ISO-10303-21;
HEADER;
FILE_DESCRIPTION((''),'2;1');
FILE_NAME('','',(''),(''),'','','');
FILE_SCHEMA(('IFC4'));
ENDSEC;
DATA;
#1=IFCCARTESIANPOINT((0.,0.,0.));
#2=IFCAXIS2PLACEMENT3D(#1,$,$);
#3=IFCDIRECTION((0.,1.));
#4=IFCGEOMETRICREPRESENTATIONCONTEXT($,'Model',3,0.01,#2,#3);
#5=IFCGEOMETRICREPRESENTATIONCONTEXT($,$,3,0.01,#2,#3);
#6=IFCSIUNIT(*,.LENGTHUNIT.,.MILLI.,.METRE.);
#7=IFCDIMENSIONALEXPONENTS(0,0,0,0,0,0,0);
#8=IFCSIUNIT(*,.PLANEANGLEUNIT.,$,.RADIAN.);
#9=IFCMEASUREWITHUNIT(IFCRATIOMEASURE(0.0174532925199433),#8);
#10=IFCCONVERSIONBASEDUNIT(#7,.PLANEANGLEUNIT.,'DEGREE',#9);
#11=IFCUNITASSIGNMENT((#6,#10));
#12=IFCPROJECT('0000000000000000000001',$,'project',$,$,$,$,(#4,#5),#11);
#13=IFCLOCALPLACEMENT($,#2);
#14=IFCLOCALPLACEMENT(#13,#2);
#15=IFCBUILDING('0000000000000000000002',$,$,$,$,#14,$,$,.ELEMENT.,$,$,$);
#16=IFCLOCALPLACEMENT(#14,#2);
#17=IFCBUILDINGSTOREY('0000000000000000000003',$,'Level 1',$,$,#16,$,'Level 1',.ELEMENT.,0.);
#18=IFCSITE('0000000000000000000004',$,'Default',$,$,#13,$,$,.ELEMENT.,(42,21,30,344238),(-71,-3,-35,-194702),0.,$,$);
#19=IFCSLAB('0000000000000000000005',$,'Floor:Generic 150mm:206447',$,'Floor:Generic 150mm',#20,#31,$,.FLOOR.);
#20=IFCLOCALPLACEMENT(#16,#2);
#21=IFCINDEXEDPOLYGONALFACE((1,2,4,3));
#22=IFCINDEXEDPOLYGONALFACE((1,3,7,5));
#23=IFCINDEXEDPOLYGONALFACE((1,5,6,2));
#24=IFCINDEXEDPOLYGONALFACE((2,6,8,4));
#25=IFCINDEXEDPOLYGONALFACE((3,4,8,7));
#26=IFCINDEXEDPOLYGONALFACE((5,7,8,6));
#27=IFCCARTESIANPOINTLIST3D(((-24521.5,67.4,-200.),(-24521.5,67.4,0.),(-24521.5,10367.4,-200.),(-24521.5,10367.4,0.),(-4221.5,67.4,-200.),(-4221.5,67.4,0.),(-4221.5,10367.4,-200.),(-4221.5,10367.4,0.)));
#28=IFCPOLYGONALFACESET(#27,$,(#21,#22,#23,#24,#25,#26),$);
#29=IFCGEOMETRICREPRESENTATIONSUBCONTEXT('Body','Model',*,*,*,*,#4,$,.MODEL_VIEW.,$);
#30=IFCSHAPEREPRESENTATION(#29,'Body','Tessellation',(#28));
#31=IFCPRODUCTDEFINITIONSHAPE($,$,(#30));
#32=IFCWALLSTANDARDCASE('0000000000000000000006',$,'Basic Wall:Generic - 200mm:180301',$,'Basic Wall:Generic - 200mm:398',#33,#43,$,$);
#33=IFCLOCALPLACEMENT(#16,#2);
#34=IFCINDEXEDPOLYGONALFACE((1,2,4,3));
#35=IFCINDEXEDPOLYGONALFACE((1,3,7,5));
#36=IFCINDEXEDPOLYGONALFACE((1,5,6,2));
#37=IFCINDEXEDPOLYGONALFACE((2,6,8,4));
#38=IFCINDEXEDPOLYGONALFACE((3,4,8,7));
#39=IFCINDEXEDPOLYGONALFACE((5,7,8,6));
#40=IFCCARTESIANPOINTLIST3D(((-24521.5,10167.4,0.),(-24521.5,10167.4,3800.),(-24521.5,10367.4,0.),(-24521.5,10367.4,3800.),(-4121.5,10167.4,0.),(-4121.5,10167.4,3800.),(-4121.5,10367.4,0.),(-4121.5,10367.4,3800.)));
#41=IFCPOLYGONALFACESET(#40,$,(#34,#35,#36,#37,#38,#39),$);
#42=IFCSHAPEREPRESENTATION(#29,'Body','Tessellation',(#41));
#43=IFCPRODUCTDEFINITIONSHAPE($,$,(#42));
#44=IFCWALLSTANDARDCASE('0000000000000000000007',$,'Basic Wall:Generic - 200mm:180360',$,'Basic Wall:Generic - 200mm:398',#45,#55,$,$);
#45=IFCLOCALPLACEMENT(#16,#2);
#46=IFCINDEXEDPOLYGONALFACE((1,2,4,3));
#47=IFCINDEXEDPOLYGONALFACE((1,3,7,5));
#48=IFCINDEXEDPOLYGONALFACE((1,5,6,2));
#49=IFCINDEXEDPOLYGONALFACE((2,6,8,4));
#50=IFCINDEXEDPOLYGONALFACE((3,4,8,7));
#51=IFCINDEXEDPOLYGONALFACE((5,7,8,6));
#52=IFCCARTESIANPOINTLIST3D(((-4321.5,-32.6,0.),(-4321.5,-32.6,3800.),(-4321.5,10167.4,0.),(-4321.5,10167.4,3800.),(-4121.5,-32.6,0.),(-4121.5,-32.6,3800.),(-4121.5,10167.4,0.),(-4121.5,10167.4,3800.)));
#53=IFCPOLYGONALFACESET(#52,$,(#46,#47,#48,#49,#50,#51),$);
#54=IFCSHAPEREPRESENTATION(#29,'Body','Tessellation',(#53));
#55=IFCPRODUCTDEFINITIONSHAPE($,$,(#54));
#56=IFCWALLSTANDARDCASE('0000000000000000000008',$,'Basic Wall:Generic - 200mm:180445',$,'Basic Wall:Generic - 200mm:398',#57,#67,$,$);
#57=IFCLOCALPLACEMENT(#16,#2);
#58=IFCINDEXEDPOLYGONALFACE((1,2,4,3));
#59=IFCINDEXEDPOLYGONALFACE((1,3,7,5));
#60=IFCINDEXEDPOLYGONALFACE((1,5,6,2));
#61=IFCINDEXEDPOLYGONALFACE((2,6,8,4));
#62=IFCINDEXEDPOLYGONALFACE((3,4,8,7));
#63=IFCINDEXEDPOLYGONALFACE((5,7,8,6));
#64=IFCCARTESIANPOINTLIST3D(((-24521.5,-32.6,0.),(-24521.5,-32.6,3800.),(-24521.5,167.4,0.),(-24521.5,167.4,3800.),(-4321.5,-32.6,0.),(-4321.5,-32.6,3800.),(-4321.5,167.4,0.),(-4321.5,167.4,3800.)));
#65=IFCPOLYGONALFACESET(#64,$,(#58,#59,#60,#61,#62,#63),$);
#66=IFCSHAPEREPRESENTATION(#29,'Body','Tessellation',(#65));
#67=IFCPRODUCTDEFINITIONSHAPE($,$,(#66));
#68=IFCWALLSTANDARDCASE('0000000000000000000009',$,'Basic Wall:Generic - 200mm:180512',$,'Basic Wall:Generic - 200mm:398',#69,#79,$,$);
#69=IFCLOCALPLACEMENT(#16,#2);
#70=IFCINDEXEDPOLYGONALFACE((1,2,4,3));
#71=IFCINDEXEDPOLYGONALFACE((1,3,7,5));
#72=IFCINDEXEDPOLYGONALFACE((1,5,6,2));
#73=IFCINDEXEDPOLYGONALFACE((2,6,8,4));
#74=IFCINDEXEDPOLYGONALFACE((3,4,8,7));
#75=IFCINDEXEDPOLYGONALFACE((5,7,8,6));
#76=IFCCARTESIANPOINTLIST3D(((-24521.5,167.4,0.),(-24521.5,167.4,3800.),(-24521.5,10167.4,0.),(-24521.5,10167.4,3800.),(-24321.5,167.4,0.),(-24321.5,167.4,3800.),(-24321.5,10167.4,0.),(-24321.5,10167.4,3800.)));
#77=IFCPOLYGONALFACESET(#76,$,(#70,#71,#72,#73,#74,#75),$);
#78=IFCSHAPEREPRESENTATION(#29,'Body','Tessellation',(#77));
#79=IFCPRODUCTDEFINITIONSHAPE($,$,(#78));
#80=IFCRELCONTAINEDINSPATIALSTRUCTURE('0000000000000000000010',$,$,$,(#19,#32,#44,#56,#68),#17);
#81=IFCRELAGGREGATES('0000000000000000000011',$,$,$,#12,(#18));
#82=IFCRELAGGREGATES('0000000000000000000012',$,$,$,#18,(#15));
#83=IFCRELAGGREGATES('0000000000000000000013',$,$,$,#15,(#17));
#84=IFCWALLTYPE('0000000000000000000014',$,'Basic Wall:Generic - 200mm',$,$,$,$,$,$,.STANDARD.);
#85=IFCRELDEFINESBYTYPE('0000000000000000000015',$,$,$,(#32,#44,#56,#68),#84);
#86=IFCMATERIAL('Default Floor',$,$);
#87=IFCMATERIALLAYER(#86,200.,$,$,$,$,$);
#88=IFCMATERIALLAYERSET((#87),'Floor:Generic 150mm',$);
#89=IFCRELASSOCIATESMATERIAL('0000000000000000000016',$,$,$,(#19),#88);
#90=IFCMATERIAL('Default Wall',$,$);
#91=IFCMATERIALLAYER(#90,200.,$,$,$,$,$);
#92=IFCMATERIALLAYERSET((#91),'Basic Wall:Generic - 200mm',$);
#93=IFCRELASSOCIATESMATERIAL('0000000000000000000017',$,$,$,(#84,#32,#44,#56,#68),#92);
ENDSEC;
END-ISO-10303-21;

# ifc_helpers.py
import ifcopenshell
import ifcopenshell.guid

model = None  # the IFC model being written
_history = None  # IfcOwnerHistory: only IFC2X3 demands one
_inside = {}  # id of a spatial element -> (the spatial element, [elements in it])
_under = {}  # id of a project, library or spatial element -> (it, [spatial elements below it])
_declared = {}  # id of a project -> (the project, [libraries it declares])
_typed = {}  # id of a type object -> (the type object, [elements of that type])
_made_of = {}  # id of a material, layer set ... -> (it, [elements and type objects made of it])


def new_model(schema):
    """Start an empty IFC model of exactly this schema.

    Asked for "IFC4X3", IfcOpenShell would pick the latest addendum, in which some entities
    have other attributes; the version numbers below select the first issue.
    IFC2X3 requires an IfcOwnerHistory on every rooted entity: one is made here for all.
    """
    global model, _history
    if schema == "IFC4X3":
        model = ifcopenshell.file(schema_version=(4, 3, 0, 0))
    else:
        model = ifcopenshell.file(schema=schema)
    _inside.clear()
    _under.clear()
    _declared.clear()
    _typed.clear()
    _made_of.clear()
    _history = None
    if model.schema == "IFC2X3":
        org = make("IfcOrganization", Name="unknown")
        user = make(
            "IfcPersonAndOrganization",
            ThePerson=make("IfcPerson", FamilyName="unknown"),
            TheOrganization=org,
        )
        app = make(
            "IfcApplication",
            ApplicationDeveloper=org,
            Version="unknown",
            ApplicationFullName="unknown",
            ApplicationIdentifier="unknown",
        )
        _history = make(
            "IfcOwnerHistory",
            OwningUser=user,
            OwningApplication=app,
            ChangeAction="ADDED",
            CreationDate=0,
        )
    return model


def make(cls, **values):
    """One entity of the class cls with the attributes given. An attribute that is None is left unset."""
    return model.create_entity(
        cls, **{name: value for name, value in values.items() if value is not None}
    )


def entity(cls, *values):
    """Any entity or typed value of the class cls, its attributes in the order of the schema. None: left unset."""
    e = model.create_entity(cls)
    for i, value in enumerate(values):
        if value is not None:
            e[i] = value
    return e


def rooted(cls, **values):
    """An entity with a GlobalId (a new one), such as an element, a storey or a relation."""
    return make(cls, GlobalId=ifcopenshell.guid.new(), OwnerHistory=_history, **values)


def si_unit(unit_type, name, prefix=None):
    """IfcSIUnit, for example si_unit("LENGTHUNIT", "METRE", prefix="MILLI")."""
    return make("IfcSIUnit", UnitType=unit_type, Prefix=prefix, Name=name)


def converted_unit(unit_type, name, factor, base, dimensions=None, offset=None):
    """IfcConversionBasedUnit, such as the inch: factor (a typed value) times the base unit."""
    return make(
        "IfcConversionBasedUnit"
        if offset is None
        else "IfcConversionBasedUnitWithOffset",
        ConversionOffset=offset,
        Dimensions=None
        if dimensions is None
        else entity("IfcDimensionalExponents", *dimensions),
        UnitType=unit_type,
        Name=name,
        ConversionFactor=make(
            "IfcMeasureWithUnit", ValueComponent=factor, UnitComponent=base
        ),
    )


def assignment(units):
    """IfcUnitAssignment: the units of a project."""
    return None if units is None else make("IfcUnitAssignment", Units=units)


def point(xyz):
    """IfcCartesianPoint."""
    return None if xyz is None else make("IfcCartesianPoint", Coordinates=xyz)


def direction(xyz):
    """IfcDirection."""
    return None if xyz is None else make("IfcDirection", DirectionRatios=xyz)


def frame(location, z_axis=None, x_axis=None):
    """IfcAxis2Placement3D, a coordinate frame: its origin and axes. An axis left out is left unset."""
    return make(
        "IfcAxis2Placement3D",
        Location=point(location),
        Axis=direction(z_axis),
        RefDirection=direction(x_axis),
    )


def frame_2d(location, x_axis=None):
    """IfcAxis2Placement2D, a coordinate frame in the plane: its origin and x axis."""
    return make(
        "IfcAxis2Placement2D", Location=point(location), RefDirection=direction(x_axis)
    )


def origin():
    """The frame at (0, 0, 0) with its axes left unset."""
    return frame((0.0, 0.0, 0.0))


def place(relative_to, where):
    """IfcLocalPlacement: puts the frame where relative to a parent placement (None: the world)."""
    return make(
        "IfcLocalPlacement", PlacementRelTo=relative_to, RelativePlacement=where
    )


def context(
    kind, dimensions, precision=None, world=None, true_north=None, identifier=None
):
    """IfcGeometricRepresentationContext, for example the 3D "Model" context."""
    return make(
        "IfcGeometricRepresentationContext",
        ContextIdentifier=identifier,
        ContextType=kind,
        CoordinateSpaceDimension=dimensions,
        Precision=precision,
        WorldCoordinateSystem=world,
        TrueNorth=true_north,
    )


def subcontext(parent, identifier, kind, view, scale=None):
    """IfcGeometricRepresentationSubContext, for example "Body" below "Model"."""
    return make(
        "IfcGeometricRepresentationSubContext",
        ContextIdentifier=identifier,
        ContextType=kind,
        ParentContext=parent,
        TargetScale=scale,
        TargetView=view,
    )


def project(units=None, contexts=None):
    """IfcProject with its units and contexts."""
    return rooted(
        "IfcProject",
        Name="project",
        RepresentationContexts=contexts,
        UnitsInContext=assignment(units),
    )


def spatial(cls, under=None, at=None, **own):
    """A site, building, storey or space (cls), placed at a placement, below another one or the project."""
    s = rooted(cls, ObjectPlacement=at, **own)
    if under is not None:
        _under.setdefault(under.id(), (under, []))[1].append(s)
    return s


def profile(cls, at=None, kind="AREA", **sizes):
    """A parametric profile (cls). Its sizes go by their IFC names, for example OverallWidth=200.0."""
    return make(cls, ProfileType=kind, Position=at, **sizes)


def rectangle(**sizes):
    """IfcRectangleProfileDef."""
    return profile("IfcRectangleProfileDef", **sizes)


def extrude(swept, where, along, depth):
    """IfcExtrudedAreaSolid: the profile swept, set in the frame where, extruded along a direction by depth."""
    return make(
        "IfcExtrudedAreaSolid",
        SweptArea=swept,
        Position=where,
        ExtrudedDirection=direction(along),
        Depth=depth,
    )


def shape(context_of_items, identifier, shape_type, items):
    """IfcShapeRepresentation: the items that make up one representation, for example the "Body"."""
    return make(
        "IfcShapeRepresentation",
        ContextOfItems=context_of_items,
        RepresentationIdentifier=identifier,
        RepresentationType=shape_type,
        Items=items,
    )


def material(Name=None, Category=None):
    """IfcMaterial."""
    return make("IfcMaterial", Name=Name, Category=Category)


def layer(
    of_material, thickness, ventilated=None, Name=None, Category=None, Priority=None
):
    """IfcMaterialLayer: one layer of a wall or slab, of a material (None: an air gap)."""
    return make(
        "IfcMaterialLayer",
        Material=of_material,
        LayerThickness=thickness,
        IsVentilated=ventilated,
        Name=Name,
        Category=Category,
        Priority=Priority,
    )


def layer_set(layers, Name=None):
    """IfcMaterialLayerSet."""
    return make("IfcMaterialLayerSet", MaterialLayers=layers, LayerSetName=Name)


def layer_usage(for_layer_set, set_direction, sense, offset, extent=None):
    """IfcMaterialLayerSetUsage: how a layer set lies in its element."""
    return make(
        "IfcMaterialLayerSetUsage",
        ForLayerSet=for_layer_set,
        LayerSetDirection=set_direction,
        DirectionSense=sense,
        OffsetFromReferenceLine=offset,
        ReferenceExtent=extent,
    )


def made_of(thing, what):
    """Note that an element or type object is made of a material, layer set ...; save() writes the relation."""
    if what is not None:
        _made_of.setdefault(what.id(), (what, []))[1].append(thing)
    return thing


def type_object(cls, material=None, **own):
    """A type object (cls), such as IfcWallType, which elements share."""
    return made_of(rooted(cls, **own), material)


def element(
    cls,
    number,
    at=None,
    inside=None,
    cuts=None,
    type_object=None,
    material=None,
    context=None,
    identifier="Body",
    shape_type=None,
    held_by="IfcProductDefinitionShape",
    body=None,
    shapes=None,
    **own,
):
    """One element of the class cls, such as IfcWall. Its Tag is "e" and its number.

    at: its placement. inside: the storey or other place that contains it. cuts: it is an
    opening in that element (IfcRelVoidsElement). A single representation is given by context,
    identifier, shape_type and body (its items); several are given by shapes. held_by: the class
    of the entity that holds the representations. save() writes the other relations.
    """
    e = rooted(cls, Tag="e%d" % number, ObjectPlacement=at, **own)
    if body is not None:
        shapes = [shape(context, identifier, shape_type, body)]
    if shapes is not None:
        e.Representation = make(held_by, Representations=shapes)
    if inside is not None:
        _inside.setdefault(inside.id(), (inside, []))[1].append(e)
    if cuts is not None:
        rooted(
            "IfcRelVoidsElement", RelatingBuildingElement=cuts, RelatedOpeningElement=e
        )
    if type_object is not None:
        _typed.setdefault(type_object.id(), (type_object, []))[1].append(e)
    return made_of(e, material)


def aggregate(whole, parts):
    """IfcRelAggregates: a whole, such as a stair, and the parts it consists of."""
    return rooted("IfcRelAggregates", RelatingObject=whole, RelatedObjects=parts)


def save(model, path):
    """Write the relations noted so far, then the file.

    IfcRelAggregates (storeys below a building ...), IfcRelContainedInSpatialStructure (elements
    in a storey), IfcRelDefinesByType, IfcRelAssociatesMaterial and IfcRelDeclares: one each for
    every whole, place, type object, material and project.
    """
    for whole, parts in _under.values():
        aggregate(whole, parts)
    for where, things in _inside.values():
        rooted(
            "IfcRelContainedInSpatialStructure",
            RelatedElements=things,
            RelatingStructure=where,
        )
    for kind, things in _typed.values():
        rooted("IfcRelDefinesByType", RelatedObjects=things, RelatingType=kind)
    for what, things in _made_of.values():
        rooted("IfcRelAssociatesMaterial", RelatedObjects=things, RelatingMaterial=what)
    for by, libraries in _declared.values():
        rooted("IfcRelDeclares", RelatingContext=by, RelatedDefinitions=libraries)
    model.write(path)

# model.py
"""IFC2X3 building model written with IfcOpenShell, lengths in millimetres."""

from ifc_helpers import new_model, entity, si_unit, converted_unit, direction, frame, frame_2d, origin, place, context, subcontext, project, spatial, rectangle, extrude, material, layer, layer_set, layer_usage, type_object, element, save


model = new_model("IFC2X3")

# Units and contexts
model_context = context("Model", 3, precision=0.01, world=origin(), true_north=direction((0.0, 1.0)))
context_of_model = context(None, 3, precision=0.01, world=origin(), true_north=direction((0.0, 1.0)))
body_context = subcontext(model_context, "Body", "Model", "MODEL_VIEW")
ifc_project = project(units=[si_unit("LENGTHUNIT", "METRE", prefix="MILLI"), converted_unit("PLANEANGLEUNIT", "DEGREE", entity("IfcRatioMeasure", 0.0174532925199433), si_unit("PLANEANGLEUNIT", "RADIAN"), dimensions=[0, 0, 0, 0, 0, 0, 0])], contexts=[model_context, context_of_model])

# Site, building, storey
site_placement = place(None, origin())
site = spatial("IfcSite", under=ifc_project, at=site_placement, Name="Default", CompositionType="ELEMENT", RefLatitude=(42, 21, 30, 344238), RefLongitude=(-71, -3, -35, -194702), RefElevation=0.0)
building_placement = place(site_placement, origin())
building = spatial("IfcBuilding", under=site, at=building_placement, CompositionType="ELEMENT")
storey_placement = place(building_placement, origin())
storey = spatial("IfcBuildingStorey", under=building, at=storey_placement, Name="Level 1", LongName="Level 1", CompositionType="ELEMENT", Elevation=0.0)

# Slab
ifc_material_1 = material(Name="Default Floor")
ifc_layer_1 = layer(ifc_material_1, 200.0)
ifc_layer_set_1 = layer_set([ifc_layer_1], Name="Floor:Generic 150mm")
ifc_layer_usage_1 = layer_usage(ifc_layer_set_1, "AXIS3", "POSITIVE", 0.0)
slab_placement = place(storey_placement, origin())
element("IfcSlab", 1, at=slab_placement, inside=storey, material=ifc_layer_usage_1, Name="Floor:Generic 150mm:206447", ObjectType="Floor:Generic 150mm", PredefinedType="FLOOR", context=body_context, shape_type="SweptSolid", body=[
    extrude(rectangle(XDim=10300.0, YDim=20300.0, at=frame_2d((0.0, 0.0), x_axis=(1.0, 0.0))), frame((-14371.5, 5217.4, 0.0), z_axis=(0.0, 0.0, -1.0), x_axis=(0.0, 1.0, 0.0)), (0.0, 0.0, 1.0), 200.0),
])

# Walls
ifc_material_2 = material(Name="Default Wall")
ifc_layer_2 = layer(ifc_material_2, 200.0)
ifc_layer_set_2 = layer_set([ifc_layer_2], Name="Basic Wall:Generic - 200mm")
ifc_layer_usage_2 = layer_usage(ifc_layer_set_2, "AXIS2", "NEGATIVE", 100.0)
wall_type = type_object("IfcWallType", Name="Basic Wall:Generic - 200mm", PredefinedType="STANDARD", material=ifc_layer_set_2)
wall_1_placement = place(storey_placement, frame((-24521.5, 10267.4, 0.0)))
element("IfcWallStandardCase", 2, at=wall_1_placement, inside=storey, type_object=wall_type, material=ifc_layer_usage_2, Name="Basic Wall:Generic - 200mm:180301", ObjectType="Basic Wall:Generic - 200mm:398", context=body_context, shape_type="SweptSolid", body=[
    extrude(rectangle(XDim=20400.0, YDim=200.0, at=frame_2d((10200.0, 0.0), x_axis=(-1.0, 0.0))), origin(), (0.0, 0.0, 1.0), 3800.0),
])
ifc_layer_usage_3 = layer_usage(ifc_layer_set_2, "AXIS2", "NEGATIVE", 100.0)
wall_2_placement = place(storey_placement, frame((-4221.5, 10167.4, 0.0), z_axis=(0.0, 0.0, 1.0), x_axis=(0.0, -1.0, 0.0)))
element("IfcWallStandardCase", 3, at=wall_2_placement, inside=storey, type_object=wall_type, material=ifc_layer_usage_3, Name="Basic Wall:Generic - 200mm:180360", ObjectType="Basic Wall:Generic - 200mm:398", context=body_context, shape_type="SweptSolid", body=[
    extrude(rectangle(XDim=10200.0, YDim=200.0, at=frame_2d((5100.0, 0.0), x_axis=(-1.0, 0.0))), origin(), (0.0, 0.0, 1.0), 3800.0),
])
ifc_layer_usage_4 = layer_usage(ifc_layer_set_2, "AXIS2", "NEGATIVE", 100.0)
wall_3_placement = place(storey_placement, frame((-4321.5, 67.4, 0.0), z_axis=(0.0, 0.0, 1.0), x_axis=(-1.0, 0.0, 0.0)))
element("IfcWallStandardCase", 4, at=wall_3_placement, inside=storey, type_object=wall_type, material=ifc_layer_usage_4, Name="Basic Wall:Generic - 200mm:180445", ObjectType="Basic Wall:Generic - 200mm:398", context=body_context, shape_type="SweptSolid", body=[
    extrude(rectangle(XDim=20200.0, YDim=200.0, at=frame_2d((10100.0, 0.0), x_axis=(-1.0, 0.0))), origin(), (0.0, 0.0, 1.0), 3800.0),
])
ifc_layer_usage_5 = layer_usage(ifc_layer_set_2, "AXIS2", "NEGATIVE", 100.0)
wall_4_placement = place(storey_placement, frame((-24421.5, 167.4, 0.0), z_axis=(0.0, 0.0, 1.0), x_axis=(0.0, 1.0, 0.0)))
element("IfcWallStandardCase", 5, at=wall_4_placement, inside=storey, type_object=wall_type, material=ifc_layer_usage_5, Name="Basic Wall:Generic - 200mm:180512", ObjectType="Basic Wall:Generic - 200mm:398", context=body_context, shape_type="SweptSolid", body=[
    extrude(rectangle(XDim=10000.0, YDim=200.0, at=frame_2d((5000.0, 0.0), x_axis=(-1.0, 0.0))), origin(), (0.0, 0.0, 1.0), 3800.0),
])

save(model, "model.ifc")
